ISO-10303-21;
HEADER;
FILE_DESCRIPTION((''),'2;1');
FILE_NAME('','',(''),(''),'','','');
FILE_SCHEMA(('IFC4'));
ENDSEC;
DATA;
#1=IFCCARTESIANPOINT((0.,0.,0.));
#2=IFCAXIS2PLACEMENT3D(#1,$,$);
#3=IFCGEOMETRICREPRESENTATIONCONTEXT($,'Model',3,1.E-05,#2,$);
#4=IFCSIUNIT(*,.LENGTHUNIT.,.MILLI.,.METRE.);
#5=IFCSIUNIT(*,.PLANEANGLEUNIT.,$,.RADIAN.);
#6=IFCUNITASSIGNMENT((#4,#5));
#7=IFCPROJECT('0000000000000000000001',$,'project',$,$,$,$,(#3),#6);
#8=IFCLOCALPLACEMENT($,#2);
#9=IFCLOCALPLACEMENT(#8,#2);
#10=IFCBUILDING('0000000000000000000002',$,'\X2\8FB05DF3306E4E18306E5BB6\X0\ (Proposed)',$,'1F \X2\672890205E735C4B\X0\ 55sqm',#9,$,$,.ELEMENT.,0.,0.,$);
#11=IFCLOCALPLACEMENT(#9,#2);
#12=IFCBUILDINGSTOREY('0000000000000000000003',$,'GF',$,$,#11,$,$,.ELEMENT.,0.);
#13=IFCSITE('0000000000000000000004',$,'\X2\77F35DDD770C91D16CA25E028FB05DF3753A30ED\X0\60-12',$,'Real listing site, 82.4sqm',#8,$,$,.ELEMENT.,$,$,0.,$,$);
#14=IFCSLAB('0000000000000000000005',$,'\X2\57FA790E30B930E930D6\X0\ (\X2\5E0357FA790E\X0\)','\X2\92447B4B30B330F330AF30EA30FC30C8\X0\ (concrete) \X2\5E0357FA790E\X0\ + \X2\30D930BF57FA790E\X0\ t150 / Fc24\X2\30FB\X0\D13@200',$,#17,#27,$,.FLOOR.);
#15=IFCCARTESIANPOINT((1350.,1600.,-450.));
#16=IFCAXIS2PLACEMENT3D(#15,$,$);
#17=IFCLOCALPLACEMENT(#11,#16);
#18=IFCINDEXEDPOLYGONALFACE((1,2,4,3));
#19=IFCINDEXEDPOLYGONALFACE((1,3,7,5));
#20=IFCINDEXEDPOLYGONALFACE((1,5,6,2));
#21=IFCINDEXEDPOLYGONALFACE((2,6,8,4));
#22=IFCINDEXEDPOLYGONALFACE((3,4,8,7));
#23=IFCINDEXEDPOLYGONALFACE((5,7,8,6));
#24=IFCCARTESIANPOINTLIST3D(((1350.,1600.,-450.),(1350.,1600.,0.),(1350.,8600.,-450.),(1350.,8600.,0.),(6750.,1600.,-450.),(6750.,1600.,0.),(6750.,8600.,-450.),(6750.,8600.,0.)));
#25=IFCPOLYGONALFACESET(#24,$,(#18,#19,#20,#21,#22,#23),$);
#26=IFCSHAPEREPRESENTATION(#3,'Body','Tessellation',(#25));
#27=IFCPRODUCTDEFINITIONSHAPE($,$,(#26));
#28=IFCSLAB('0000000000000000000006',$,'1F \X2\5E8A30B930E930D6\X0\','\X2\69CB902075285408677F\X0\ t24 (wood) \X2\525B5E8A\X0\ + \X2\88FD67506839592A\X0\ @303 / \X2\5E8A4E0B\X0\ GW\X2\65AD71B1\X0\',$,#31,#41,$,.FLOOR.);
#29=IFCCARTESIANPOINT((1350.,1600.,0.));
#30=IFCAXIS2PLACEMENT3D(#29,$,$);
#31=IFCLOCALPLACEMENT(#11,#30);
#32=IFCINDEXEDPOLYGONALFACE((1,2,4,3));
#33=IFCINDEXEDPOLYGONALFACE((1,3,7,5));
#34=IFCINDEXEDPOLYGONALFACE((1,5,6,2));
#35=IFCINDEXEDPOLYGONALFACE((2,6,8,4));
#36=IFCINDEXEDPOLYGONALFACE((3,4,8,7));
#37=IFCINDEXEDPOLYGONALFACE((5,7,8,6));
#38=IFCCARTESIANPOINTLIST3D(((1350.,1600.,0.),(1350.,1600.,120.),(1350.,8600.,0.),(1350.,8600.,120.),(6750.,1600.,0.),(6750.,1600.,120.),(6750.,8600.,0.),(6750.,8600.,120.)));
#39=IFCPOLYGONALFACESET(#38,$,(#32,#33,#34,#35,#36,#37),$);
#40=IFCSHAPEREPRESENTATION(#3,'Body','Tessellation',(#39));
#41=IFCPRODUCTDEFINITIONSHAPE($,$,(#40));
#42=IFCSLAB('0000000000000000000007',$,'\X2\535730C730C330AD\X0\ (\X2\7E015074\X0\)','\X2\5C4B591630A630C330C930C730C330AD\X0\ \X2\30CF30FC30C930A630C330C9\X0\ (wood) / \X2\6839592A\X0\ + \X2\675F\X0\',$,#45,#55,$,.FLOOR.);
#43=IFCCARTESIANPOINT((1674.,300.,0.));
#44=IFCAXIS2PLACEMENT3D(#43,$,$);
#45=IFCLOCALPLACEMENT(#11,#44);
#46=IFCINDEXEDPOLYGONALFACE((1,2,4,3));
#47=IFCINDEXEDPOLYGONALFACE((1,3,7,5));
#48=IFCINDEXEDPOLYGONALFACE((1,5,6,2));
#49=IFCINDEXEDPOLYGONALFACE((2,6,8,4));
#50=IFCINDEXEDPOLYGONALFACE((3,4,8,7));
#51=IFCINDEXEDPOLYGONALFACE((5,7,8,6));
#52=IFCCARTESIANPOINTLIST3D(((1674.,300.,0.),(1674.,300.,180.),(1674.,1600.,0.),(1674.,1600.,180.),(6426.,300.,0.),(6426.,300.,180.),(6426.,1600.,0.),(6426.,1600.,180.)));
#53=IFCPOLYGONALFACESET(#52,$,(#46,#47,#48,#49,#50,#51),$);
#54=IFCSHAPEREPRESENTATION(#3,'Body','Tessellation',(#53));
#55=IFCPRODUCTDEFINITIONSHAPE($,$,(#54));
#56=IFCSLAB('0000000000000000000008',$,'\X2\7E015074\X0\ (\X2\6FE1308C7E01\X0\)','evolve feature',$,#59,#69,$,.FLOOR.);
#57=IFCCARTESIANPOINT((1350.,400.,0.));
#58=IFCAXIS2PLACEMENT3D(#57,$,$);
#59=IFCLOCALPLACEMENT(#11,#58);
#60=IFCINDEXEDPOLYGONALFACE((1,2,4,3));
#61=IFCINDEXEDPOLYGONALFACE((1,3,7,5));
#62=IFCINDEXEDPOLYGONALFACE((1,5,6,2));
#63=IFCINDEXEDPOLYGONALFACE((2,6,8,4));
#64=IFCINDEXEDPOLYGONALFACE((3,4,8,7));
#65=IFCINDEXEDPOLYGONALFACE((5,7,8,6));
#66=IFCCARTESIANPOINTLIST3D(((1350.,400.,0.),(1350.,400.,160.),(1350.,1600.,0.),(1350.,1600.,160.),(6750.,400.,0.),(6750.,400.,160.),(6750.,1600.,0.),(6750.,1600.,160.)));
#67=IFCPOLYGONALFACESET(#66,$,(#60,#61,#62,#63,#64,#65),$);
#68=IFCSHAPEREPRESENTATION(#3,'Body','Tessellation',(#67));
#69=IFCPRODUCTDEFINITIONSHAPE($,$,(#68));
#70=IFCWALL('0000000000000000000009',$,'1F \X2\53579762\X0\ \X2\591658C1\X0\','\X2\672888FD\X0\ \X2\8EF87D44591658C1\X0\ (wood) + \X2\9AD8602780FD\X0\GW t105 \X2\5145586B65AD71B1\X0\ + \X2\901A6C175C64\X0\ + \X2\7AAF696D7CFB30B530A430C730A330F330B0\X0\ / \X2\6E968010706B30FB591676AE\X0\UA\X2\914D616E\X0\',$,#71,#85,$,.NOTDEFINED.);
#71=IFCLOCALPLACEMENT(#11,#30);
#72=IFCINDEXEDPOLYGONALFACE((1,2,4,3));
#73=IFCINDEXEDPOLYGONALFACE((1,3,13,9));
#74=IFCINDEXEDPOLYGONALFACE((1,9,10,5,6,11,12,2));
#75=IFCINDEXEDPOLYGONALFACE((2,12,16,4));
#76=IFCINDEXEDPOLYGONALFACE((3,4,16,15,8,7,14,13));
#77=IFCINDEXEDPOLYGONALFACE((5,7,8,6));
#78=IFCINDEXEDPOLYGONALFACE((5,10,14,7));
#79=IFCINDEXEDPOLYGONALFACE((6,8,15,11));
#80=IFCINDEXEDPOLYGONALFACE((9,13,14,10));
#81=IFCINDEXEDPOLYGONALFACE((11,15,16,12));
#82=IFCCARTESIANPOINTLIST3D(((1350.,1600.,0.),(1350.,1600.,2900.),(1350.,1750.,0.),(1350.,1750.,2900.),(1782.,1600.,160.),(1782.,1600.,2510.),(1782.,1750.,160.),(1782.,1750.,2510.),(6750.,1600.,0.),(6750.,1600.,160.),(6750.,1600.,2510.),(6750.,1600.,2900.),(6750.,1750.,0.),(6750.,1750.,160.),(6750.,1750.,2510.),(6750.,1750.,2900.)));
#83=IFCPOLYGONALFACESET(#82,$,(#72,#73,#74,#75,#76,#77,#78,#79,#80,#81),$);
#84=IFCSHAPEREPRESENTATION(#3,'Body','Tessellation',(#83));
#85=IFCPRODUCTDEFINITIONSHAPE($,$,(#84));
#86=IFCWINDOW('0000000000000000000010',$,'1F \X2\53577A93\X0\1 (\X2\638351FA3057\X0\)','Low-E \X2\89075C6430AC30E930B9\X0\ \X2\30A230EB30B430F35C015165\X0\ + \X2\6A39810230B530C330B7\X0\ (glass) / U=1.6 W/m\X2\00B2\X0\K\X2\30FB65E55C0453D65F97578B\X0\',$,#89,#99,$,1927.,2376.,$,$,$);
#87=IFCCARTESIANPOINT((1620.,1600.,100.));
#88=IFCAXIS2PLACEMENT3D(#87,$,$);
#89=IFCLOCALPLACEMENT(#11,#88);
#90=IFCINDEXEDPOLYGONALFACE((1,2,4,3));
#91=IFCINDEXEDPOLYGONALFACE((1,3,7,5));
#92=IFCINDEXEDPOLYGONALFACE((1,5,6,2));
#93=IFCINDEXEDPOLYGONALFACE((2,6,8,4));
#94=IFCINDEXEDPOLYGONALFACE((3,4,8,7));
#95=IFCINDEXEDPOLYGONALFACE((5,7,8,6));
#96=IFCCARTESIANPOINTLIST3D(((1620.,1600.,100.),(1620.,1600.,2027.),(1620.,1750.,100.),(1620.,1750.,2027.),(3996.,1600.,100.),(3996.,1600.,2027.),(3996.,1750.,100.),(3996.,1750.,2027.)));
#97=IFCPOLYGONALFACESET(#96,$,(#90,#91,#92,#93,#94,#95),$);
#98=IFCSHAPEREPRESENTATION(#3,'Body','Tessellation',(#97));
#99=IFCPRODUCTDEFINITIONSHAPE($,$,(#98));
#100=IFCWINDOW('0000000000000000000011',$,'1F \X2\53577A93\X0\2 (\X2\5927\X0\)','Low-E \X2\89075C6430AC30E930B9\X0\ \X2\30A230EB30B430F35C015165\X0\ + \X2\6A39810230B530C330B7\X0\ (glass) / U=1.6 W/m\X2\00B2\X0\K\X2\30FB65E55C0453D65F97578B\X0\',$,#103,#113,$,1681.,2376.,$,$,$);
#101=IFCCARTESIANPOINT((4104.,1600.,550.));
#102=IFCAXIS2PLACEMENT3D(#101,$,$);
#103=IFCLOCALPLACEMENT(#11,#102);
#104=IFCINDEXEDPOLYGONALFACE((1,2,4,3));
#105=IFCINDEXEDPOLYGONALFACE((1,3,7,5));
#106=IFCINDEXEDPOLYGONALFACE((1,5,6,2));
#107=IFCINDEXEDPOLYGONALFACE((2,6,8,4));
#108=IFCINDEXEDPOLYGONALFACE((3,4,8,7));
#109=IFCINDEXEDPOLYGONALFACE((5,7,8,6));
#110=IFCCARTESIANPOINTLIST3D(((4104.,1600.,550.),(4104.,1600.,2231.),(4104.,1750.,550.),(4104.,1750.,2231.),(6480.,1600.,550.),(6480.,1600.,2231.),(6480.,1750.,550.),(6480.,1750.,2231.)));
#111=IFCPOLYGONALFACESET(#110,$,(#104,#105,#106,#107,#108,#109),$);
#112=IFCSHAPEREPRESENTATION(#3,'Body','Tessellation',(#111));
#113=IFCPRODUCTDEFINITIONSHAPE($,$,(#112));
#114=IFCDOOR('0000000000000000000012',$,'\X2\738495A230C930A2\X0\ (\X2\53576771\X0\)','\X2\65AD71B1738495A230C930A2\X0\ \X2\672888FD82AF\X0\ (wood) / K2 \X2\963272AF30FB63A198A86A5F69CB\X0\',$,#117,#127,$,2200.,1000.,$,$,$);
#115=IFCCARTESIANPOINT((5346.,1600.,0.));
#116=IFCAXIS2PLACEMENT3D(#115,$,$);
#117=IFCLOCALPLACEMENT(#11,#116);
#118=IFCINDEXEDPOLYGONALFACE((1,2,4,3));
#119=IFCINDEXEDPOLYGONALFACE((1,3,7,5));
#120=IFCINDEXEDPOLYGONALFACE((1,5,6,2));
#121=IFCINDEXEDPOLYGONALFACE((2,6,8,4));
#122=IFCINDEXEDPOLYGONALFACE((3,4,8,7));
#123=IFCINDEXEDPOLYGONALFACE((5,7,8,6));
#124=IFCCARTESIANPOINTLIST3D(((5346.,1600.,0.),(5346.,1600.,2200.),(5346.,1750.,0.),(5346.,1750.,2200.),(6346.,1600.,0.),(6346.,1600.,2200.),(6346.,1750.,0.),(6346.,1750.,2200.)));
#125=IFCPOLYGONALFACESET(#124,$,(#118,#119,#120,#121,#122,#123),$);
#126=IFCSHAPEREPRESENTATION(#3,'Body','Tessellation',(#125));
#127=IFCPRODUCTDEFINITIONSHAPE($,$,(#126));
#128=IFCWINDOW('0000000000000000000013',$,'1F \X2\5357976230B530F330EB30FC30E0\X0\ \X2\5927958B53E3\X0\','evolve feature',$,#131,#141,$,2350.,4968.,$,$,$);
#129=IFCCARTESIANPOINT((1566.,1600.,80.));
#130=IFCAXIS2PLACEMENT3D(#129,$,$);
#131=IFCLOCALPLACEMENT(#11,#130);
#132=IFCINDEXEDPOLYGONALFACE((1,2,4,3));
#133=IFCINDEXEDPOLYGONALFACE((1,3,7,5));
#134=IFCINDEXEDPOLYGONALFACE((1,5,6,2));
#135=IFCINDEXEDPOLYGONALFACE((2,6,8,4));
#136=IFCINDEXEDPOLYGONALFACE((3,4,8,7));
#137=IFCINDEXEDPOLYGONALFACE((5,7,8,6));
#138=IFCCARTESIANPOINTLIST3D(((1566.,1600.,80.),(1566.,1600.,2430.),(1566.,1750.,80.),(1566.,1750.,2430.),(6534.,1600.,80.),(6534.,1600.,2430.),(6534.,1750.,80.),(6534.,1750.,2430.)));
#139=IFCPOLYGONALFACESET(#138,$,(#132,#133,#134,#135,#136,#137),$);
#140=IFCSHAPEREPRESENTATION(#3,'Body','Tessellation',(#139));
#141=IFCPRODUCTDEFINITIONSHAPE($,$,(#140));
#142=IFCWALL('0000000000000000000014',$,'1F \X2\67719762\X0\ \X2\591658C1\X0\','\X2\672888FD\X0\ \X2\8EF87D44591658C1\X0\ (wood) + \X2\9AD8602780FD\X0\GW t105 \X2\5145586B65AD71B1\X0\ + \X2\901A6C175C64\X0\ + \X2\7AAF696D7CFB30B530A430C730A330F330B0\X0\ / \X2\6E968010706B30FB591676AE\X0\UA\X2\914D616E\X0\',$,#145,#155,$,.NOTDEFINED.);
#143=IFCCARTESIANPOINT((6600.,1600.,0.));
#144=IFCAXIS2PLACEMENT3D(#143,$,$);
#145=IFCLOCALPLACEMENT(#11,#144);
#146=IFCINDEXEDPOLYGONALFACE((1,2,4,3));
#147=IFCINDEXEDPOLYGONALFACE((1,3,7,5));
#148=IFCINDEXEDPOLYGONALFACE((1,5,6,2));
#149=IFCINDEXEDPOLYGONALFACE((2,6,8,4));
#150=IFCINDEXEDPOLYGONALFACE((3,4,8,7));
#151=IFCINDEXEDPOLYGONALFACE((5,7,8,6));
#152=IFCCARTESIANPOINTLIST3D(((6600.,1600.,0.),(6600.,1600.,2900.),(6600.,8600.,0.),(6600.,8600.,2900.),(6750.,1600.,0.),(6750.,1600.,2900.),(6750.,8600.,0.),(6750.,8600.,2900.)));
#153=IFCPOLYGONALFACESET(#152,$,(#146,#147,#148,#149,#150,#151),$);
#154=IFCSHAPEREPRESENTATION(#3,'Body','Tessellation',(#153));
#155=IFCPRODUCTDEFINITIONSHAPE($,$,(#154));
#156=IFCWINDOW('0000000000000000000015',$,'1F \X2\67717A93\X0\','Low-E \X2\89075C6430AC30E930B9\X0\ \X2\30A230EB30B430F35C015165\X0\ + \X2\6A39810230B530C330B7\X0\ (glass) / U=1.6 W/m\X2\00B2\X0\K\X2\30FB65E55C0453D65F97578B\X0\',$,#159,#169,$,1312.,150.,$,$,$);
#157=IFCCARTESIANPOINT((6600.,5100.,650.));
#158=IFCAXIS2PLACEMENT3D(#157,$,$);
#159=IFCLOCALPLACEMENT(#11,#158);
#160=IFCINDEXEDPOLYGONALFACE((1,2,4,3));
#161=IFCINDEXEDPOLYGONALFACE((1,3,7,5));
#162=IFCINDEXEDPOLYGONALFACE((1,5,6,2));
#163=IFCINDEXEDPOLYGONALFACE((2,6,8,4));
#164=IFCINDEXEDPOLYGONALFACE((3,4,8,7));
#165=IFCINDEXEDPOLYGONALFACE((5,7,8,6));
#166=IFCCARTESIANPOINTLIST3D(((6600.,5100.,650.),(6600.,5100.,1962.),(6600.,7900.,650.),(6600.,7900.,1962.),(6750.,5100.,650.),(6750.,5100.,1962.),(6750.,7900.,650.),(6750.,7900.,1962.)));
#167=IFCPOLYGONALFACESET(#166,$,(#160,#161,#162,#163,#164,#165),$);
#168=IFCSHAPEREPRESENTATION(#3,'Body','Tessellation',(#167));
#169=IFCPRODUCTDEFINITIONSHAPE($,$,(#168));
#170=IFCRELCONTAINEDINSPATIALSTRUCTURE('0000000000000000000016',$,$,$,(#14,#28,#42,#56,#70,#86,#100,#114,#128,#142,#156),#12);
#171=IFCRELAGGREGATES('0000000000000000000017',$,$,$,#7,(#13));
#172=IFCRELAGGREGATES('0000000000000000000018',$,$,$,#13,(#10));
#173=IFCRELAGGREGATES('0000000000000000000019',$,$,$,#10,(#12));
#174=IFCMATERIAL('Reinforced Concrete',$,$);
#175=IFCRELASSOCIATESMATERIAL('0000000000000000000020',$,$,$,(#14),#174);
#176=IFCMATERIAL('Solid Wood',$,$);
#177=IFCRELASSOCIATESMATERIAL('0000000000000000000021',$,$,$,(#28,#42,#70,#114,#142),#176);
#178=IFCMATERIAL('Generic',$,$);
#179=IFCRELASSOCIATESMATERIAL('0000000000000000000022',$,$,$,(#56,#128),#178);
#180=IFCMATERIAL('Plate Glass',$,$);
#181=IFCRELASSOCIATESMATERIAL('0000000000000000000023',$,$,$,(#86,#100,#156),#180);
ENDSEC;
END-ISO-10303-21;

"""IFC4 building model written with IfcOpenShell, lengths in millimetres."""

from ifc_helpers import new_model, si_unit, frame, frame_2d, origin, place, context, project, spatial, rectangle, extrude, material, element, fill, save


model = new_model("IFC4")

# Units and contexts
model_context = context("Model", 3, precision=1e-05, world=origin())
ifc_project = project(units=[si_unit("LENGTHUNIT", "METRE", prefix="MILLI"), si_unit("PLANEANGLEUNIT", "RADIAN")], contexts=[model_context])

# Site, building, storey
site_placement = place(None, origin())
site = spatial("IfcSite", under=ifc_project, at=site_placement, Name="石川県金沢市辰巳町ロ60-12", ObjectType="Real listing site, 82.4sqm", CompositionType="ELEMENT", RefElevation=0.0)
building_placement = place(site_placement, origin())
building = spatial("IfcBuilding", under=site, at=building_placement, Name="辰巳の丘の家 (Proposed)", ObjectType="1F 木造平屋 55sqm", CompositionType="ELEMENT", ElevationOfRefHeight=0.0, ElevationOfTerrain=0.0)
storey_placement = place(building_placement, origin())
storey = spatial("IfcBuildingStorey", under=building, at=storey_placement, Name="GF", CompositionType="ELEMENT", Elevation=0.0)

# Slabs
ifc_material_1 = material(Name="Reinforced Concrete")
slab_1_placement = place(storey_placement, frame((1350.0, 1600.0, -450.0)))
element("IfcSlab", 1, at=slab_1_placement, inside=storey, material=ifc_material_1, Name="基礎スラブ (布基礎)", Description="鉄筋コンクリート (concrete) 布基礎 + ベタ基礎 t150 / Fc24・D13@200", PredefinedType="FLOOR", context=model_context, shape_type="SweptSolid", body=[
    extrude(rectangle(XDim=5400.0, YDim=7000.0, at=frame_2d((2700.0, 3500.0))), frame((1350.0, 1600.0, -450.0)), (0.0, 0.0, 1.0), 450.0),
])
ifc_material_2 = material(Name="Solid Wood")
slab_2_placement = place(storey_placement, frame((1350.0, 1600.0, 0.0)))
element("IfcSlab", 2, at=slab_2_placement, inside=storey, material=ifc_material_2, Name="1F 床スラブ", Description="構造用合板 t24 (wood) 剛床 + 製材根太 @303 / 床下 GW断熱", PredefinedType="FLOOR", context=model_context, shape_type="SweptSolid", body=[
    extrude(rectangle(XDim=5400.0, YDim=7000.0, at=frame_2d((2700.0, 3500.0))), frame((1350.0, 1600.0, 0.0)), (0.0, 0.0, 1.0), 120.0),
])
slab_3_placement = place(storey_placement, frame((1674.0, 300.0, 0.0)))
element("IfcSlab", 3, at=slab_3_placement, inside=storey, material=ifc_material_2, Name="南デッキ (縁側)", Description="屋外ウッドデッキ ハードウッド (wood) / 根太 + 束", PredefinedType="FLOOR", context=model_context, shape_type="SweptSolid", body=[
    extrude(rectangle(XDim=4752.0, YDim=1300.0, at=frame_2d((2376.0, 650.0))), frame((1674.0, 300.0, 0.0)), (0.0, 0.0, 1.0), 180.0),
])
ifc_material_3 = material(Name="Generic")
slab_4_placement = place(storey_placement, frame((1350.0, 400.0, 0.0)))
element("IfcSlab", 4, at=slab_4_placement, inside=storey, material=ifc_material_3, Name="縁側 (濡れ縁)", Description="evolve feature", PredefinedType="FLOOR", context=model_context, shape_type="SweptSolid", body=[
    extrude(rectangle(XDim=5400.0, YDim=1200.0, at=frame_2d((2700.0, 600.0))), frame((1350.0, 400.0, 0.0)), (0.0, 0.0, 1.0), 160.0),
])

# Wall, openings, windows, door
wall_1_placement = place(storey_placement, frame((1350.0, 1600.0, 0.0)))
wall_1 = element("IfcWall", 5, at=wall_1_placement, inside=storey, material=ifc_material_2, Name="1F 南面 外壁", Description="木製 軸組外壁 (wood) + 高性能GW t105 充填断熱 + 通気層 + 窯業系サイディング / 準耐火・外皮UA配慮", PredefinedType="NOTDEFINED", context=model_context, shape_type="SweptSolid", body=[
    extrude(rectangle(XDim=5400.0, YDim=150.0, at=frame_2d((2700.0, 75.0))), frame((1350.0, 1600.0, 0.0)), (0.0, 0.0, 1.0), 2900.0),
])
opening_1_placement = place(storey_placement, frame((1620.0, 1600.0, 100.0)))
opening_1 = element("IfcOpeningElement", 6, at=opening_1_placement, cuts=wall_1, PredefinedType="NOTDEFINED", context=model_context, shape_type="SweptSolid", body=[
    extrude(rectangle(XDim=2376.0, YDim=150.0, at=frame_2d((1188.0, 75.0))), frame((1620.0, 1600.0, 100.0)), (0.0, 0.0, 1.0), 1927.0),
])
opening_2_placement = place(storey_placement, frame((4104.0, 1600.0, 550.0)))
opening_2 = element("IfcOpeningElement", 7, at=opening_2_placement, cuts=wall_1, PredefinedType="NOTDEFINED", context=model_context, shape_type="SweptSolid", body=[
    extrude(rectangle(XDim=2376.0, YDim=150.0, at=frame_2d((1188.0, 75.0))), frame((4104.0, 1600.0, 550.0)), (0.0, 0.0, 1.0), 1681.0),
])
opening_3_placement = place(storey_placement, frame((5346.0, 1600.0, 0.0)))
opening_3 = element("IfcOpeningElement", 8, at=opening_3_placement, cuts=wall_1, PredefinedType="NOTDEFINED", context=model_context, shape_type="SweptSolid", body=[
    extrude(rectangle(XDim=1000.0, YDim=150.0, at=frame_2d((500.0, 75.0))), frame((5346.0, 1600.0, 0.0)), (0.0, 0.0, 1.0), 2200.0),
])
opening_4_placement = place(storey_placement, frame((1566.0, 1600.0, 80.0)))
opening_4 = element("IfcOpeningElement", 9, at=opening_4_placement, cuts=wall_1, PredefinedType="NOTDEFINED", context=model_context, shape_type="SweptSolid", body=[
    extrude(rectangle(XDim=4968.0, YDim=150.0, at=frame_2d((2484.0, 75.0))), frame((1566.0, 1600.0, 80.0)), (0.0, 0.0, 1.0), 2350.0),
])
ifc_material_4 = material(Name="Plate Glass")
window_1_placement = place(storey_placement, frame((1620.0, 1600.0, 100.0)))
window_1 = element("IfcWindow", 10, at=window_1_placement, inside=storey, material=ifc_material_4, Name="1F 南窓1 (掃出し)", Description="Low-E 複層ガラス アルゴン封入 + 樹脂サッシ (glass) / U=1.6 W/m²K・日射取得型", OverallHeight=1927.0, OverallWidth=2376.0, context=model_context, shape_type="SweptSolid", body=[
    extrude(rectangle(XDim=2376.0, YDim=150.0, at=frame_2d((1188.0, 75.0))), frame((1620.0, 1600.0, 100.0)), (0.0, 0.0, 1.0), 1927.0),
])
fill(opening_1, window_1)
window_2_placement = place(storey_placement, frame((4104.0, 1600.0, 550.0)))
window_2 = element("IfcWindow", 11, at=window_2_placement, inside=storey, material=ifc_material_4, Name="1F 南窓2 (大)", Description="Low-E 複層ガラス アルゴン封入 + 樹脂サッシ (glass) / U=1.6 W/m²K・日射取得型", OverallHeight=1681.0, OverallWidth=2376.0, context=model_context, shape_type="SweptSolid", body=[
    extrude(rectangle(XDim=2376.0, YDim=150.0, at=frame_2d((1188.0, 75.0))), frame((4104.0, 1600.0, 550.0)), (0.0, 0.0, 1.0), 1681.0),
])
fill(opening_2, window_2)
door_placement = place(storey_placement, frame((5346.0, 1600.0, 0.0)))
door = element("IfcDoor", 12, at=door_placement, inside=storey, material=ifc_material_2, Name="玄関ドア (南東)", Description="断熱玄関ドア 木製芯 (wood) / K2 防犯・採風機構", OverallHeight=2200.0, OverallWidth=1000.0, context=model_context, shape_type="SweptSolid", body=[
    extrude(rectangle(XDim=1000.0, YDim=150.0, at=frame_2d((500.0, 75.0))), frame((5346.0, 1600.0, 0.0)), (0.0, 0.0, 1.0), 2200.0),
])
fill(opening_3, door)
window_3_placement = place(storey_placement, frame((1566.0, 1600.0, 80.0)))
window_3 = element("IfcWindow", 13, at=window_3_placement, inside=storey, material=ifc_material_3, Name="1F 南面サンルーム 大開口", Description="evolve feature", OverallHeight=2350.0, OverallWidth=4968.0, context=model_context, shape_type="SweptSolid", body=[
    extrude(rectangle(XDim=4968.0, YDim=150.0, at=frame_2d((2484.0, 75.0))), frame((1566.0, 1600.0, 80.0)), (0.0, 0.0, 1.0), 2350.0),
])
fill(opening_4, window_3)

# Wall, opening, window
wall_2_placement = place(storey_placement, frame((6600.0, 1600.0, 0.0)))
wall_2 = element("IfcWall", 14, at=wall_2_placement, inside=storey, material=ifc_material_2, Name="1F 東面 外壁", Description="木製 軸組外壁 (wood) + 高性能GW t105 充填断熱 + 通気層 + 窯業系サイディング / 準耐火・外皮UA配慮", PredefinedType="NOTDEFINED", context=model_context, shape_type="SweptSolid", body=[
    extrude(rectangle(XDim=150.0, YDim=7000.0, at=frame_2d((75.0, 3500.0))), frame((6600.0, 1600.0, 0.0)), (0.0, 0.0, 1.0), 2900.0),
])
opening_5_placement = place(storey_placement, frame((6600.0, 5100.0, 650.0)))
opening_5 = element("IfcOpeningElement", 15, at=opening_5_placement, cuts=wall_2, PredefinedType="NOTDEFINED", context=model_context, shape_type="SweptSolid", body=[
    extrude(rectangle(XDim=150.0, YDim=2800.0, at=frame_2d((75.0, 1400.0))), frame((6600.0, 5100.0, 650.0)), (0.0, 0.0, 1.0), 1312.0),
])
window_4_placement = place(storey_placement, frame((6600.0, 5100.0, 650.0)))
window_4 = element("IfcWindow", 16, at=window_4_placement, inside=storey, material=ifc_material_4, Name="1F 東窓", Description="Low-E 複層ガラス アルゴン封入 + 樹脂サッシ (glass) / U=1.6 W/m²K・日射取得型", OverallHeight=1312.0, OverallWidth=150.0, context=model_context, shape_type="SweptSolid", body=[
    extrude(rectangle(XDim=150.0, YDim=2800.0, at=frame_2d((75.0, 1400.0))), frame((6600.0, 5100.0, 650.0)), (0.0, 0.0, 1.0), 1312.0),
])
fill(opening_5, window_4)

save(model, "model.ifc")
